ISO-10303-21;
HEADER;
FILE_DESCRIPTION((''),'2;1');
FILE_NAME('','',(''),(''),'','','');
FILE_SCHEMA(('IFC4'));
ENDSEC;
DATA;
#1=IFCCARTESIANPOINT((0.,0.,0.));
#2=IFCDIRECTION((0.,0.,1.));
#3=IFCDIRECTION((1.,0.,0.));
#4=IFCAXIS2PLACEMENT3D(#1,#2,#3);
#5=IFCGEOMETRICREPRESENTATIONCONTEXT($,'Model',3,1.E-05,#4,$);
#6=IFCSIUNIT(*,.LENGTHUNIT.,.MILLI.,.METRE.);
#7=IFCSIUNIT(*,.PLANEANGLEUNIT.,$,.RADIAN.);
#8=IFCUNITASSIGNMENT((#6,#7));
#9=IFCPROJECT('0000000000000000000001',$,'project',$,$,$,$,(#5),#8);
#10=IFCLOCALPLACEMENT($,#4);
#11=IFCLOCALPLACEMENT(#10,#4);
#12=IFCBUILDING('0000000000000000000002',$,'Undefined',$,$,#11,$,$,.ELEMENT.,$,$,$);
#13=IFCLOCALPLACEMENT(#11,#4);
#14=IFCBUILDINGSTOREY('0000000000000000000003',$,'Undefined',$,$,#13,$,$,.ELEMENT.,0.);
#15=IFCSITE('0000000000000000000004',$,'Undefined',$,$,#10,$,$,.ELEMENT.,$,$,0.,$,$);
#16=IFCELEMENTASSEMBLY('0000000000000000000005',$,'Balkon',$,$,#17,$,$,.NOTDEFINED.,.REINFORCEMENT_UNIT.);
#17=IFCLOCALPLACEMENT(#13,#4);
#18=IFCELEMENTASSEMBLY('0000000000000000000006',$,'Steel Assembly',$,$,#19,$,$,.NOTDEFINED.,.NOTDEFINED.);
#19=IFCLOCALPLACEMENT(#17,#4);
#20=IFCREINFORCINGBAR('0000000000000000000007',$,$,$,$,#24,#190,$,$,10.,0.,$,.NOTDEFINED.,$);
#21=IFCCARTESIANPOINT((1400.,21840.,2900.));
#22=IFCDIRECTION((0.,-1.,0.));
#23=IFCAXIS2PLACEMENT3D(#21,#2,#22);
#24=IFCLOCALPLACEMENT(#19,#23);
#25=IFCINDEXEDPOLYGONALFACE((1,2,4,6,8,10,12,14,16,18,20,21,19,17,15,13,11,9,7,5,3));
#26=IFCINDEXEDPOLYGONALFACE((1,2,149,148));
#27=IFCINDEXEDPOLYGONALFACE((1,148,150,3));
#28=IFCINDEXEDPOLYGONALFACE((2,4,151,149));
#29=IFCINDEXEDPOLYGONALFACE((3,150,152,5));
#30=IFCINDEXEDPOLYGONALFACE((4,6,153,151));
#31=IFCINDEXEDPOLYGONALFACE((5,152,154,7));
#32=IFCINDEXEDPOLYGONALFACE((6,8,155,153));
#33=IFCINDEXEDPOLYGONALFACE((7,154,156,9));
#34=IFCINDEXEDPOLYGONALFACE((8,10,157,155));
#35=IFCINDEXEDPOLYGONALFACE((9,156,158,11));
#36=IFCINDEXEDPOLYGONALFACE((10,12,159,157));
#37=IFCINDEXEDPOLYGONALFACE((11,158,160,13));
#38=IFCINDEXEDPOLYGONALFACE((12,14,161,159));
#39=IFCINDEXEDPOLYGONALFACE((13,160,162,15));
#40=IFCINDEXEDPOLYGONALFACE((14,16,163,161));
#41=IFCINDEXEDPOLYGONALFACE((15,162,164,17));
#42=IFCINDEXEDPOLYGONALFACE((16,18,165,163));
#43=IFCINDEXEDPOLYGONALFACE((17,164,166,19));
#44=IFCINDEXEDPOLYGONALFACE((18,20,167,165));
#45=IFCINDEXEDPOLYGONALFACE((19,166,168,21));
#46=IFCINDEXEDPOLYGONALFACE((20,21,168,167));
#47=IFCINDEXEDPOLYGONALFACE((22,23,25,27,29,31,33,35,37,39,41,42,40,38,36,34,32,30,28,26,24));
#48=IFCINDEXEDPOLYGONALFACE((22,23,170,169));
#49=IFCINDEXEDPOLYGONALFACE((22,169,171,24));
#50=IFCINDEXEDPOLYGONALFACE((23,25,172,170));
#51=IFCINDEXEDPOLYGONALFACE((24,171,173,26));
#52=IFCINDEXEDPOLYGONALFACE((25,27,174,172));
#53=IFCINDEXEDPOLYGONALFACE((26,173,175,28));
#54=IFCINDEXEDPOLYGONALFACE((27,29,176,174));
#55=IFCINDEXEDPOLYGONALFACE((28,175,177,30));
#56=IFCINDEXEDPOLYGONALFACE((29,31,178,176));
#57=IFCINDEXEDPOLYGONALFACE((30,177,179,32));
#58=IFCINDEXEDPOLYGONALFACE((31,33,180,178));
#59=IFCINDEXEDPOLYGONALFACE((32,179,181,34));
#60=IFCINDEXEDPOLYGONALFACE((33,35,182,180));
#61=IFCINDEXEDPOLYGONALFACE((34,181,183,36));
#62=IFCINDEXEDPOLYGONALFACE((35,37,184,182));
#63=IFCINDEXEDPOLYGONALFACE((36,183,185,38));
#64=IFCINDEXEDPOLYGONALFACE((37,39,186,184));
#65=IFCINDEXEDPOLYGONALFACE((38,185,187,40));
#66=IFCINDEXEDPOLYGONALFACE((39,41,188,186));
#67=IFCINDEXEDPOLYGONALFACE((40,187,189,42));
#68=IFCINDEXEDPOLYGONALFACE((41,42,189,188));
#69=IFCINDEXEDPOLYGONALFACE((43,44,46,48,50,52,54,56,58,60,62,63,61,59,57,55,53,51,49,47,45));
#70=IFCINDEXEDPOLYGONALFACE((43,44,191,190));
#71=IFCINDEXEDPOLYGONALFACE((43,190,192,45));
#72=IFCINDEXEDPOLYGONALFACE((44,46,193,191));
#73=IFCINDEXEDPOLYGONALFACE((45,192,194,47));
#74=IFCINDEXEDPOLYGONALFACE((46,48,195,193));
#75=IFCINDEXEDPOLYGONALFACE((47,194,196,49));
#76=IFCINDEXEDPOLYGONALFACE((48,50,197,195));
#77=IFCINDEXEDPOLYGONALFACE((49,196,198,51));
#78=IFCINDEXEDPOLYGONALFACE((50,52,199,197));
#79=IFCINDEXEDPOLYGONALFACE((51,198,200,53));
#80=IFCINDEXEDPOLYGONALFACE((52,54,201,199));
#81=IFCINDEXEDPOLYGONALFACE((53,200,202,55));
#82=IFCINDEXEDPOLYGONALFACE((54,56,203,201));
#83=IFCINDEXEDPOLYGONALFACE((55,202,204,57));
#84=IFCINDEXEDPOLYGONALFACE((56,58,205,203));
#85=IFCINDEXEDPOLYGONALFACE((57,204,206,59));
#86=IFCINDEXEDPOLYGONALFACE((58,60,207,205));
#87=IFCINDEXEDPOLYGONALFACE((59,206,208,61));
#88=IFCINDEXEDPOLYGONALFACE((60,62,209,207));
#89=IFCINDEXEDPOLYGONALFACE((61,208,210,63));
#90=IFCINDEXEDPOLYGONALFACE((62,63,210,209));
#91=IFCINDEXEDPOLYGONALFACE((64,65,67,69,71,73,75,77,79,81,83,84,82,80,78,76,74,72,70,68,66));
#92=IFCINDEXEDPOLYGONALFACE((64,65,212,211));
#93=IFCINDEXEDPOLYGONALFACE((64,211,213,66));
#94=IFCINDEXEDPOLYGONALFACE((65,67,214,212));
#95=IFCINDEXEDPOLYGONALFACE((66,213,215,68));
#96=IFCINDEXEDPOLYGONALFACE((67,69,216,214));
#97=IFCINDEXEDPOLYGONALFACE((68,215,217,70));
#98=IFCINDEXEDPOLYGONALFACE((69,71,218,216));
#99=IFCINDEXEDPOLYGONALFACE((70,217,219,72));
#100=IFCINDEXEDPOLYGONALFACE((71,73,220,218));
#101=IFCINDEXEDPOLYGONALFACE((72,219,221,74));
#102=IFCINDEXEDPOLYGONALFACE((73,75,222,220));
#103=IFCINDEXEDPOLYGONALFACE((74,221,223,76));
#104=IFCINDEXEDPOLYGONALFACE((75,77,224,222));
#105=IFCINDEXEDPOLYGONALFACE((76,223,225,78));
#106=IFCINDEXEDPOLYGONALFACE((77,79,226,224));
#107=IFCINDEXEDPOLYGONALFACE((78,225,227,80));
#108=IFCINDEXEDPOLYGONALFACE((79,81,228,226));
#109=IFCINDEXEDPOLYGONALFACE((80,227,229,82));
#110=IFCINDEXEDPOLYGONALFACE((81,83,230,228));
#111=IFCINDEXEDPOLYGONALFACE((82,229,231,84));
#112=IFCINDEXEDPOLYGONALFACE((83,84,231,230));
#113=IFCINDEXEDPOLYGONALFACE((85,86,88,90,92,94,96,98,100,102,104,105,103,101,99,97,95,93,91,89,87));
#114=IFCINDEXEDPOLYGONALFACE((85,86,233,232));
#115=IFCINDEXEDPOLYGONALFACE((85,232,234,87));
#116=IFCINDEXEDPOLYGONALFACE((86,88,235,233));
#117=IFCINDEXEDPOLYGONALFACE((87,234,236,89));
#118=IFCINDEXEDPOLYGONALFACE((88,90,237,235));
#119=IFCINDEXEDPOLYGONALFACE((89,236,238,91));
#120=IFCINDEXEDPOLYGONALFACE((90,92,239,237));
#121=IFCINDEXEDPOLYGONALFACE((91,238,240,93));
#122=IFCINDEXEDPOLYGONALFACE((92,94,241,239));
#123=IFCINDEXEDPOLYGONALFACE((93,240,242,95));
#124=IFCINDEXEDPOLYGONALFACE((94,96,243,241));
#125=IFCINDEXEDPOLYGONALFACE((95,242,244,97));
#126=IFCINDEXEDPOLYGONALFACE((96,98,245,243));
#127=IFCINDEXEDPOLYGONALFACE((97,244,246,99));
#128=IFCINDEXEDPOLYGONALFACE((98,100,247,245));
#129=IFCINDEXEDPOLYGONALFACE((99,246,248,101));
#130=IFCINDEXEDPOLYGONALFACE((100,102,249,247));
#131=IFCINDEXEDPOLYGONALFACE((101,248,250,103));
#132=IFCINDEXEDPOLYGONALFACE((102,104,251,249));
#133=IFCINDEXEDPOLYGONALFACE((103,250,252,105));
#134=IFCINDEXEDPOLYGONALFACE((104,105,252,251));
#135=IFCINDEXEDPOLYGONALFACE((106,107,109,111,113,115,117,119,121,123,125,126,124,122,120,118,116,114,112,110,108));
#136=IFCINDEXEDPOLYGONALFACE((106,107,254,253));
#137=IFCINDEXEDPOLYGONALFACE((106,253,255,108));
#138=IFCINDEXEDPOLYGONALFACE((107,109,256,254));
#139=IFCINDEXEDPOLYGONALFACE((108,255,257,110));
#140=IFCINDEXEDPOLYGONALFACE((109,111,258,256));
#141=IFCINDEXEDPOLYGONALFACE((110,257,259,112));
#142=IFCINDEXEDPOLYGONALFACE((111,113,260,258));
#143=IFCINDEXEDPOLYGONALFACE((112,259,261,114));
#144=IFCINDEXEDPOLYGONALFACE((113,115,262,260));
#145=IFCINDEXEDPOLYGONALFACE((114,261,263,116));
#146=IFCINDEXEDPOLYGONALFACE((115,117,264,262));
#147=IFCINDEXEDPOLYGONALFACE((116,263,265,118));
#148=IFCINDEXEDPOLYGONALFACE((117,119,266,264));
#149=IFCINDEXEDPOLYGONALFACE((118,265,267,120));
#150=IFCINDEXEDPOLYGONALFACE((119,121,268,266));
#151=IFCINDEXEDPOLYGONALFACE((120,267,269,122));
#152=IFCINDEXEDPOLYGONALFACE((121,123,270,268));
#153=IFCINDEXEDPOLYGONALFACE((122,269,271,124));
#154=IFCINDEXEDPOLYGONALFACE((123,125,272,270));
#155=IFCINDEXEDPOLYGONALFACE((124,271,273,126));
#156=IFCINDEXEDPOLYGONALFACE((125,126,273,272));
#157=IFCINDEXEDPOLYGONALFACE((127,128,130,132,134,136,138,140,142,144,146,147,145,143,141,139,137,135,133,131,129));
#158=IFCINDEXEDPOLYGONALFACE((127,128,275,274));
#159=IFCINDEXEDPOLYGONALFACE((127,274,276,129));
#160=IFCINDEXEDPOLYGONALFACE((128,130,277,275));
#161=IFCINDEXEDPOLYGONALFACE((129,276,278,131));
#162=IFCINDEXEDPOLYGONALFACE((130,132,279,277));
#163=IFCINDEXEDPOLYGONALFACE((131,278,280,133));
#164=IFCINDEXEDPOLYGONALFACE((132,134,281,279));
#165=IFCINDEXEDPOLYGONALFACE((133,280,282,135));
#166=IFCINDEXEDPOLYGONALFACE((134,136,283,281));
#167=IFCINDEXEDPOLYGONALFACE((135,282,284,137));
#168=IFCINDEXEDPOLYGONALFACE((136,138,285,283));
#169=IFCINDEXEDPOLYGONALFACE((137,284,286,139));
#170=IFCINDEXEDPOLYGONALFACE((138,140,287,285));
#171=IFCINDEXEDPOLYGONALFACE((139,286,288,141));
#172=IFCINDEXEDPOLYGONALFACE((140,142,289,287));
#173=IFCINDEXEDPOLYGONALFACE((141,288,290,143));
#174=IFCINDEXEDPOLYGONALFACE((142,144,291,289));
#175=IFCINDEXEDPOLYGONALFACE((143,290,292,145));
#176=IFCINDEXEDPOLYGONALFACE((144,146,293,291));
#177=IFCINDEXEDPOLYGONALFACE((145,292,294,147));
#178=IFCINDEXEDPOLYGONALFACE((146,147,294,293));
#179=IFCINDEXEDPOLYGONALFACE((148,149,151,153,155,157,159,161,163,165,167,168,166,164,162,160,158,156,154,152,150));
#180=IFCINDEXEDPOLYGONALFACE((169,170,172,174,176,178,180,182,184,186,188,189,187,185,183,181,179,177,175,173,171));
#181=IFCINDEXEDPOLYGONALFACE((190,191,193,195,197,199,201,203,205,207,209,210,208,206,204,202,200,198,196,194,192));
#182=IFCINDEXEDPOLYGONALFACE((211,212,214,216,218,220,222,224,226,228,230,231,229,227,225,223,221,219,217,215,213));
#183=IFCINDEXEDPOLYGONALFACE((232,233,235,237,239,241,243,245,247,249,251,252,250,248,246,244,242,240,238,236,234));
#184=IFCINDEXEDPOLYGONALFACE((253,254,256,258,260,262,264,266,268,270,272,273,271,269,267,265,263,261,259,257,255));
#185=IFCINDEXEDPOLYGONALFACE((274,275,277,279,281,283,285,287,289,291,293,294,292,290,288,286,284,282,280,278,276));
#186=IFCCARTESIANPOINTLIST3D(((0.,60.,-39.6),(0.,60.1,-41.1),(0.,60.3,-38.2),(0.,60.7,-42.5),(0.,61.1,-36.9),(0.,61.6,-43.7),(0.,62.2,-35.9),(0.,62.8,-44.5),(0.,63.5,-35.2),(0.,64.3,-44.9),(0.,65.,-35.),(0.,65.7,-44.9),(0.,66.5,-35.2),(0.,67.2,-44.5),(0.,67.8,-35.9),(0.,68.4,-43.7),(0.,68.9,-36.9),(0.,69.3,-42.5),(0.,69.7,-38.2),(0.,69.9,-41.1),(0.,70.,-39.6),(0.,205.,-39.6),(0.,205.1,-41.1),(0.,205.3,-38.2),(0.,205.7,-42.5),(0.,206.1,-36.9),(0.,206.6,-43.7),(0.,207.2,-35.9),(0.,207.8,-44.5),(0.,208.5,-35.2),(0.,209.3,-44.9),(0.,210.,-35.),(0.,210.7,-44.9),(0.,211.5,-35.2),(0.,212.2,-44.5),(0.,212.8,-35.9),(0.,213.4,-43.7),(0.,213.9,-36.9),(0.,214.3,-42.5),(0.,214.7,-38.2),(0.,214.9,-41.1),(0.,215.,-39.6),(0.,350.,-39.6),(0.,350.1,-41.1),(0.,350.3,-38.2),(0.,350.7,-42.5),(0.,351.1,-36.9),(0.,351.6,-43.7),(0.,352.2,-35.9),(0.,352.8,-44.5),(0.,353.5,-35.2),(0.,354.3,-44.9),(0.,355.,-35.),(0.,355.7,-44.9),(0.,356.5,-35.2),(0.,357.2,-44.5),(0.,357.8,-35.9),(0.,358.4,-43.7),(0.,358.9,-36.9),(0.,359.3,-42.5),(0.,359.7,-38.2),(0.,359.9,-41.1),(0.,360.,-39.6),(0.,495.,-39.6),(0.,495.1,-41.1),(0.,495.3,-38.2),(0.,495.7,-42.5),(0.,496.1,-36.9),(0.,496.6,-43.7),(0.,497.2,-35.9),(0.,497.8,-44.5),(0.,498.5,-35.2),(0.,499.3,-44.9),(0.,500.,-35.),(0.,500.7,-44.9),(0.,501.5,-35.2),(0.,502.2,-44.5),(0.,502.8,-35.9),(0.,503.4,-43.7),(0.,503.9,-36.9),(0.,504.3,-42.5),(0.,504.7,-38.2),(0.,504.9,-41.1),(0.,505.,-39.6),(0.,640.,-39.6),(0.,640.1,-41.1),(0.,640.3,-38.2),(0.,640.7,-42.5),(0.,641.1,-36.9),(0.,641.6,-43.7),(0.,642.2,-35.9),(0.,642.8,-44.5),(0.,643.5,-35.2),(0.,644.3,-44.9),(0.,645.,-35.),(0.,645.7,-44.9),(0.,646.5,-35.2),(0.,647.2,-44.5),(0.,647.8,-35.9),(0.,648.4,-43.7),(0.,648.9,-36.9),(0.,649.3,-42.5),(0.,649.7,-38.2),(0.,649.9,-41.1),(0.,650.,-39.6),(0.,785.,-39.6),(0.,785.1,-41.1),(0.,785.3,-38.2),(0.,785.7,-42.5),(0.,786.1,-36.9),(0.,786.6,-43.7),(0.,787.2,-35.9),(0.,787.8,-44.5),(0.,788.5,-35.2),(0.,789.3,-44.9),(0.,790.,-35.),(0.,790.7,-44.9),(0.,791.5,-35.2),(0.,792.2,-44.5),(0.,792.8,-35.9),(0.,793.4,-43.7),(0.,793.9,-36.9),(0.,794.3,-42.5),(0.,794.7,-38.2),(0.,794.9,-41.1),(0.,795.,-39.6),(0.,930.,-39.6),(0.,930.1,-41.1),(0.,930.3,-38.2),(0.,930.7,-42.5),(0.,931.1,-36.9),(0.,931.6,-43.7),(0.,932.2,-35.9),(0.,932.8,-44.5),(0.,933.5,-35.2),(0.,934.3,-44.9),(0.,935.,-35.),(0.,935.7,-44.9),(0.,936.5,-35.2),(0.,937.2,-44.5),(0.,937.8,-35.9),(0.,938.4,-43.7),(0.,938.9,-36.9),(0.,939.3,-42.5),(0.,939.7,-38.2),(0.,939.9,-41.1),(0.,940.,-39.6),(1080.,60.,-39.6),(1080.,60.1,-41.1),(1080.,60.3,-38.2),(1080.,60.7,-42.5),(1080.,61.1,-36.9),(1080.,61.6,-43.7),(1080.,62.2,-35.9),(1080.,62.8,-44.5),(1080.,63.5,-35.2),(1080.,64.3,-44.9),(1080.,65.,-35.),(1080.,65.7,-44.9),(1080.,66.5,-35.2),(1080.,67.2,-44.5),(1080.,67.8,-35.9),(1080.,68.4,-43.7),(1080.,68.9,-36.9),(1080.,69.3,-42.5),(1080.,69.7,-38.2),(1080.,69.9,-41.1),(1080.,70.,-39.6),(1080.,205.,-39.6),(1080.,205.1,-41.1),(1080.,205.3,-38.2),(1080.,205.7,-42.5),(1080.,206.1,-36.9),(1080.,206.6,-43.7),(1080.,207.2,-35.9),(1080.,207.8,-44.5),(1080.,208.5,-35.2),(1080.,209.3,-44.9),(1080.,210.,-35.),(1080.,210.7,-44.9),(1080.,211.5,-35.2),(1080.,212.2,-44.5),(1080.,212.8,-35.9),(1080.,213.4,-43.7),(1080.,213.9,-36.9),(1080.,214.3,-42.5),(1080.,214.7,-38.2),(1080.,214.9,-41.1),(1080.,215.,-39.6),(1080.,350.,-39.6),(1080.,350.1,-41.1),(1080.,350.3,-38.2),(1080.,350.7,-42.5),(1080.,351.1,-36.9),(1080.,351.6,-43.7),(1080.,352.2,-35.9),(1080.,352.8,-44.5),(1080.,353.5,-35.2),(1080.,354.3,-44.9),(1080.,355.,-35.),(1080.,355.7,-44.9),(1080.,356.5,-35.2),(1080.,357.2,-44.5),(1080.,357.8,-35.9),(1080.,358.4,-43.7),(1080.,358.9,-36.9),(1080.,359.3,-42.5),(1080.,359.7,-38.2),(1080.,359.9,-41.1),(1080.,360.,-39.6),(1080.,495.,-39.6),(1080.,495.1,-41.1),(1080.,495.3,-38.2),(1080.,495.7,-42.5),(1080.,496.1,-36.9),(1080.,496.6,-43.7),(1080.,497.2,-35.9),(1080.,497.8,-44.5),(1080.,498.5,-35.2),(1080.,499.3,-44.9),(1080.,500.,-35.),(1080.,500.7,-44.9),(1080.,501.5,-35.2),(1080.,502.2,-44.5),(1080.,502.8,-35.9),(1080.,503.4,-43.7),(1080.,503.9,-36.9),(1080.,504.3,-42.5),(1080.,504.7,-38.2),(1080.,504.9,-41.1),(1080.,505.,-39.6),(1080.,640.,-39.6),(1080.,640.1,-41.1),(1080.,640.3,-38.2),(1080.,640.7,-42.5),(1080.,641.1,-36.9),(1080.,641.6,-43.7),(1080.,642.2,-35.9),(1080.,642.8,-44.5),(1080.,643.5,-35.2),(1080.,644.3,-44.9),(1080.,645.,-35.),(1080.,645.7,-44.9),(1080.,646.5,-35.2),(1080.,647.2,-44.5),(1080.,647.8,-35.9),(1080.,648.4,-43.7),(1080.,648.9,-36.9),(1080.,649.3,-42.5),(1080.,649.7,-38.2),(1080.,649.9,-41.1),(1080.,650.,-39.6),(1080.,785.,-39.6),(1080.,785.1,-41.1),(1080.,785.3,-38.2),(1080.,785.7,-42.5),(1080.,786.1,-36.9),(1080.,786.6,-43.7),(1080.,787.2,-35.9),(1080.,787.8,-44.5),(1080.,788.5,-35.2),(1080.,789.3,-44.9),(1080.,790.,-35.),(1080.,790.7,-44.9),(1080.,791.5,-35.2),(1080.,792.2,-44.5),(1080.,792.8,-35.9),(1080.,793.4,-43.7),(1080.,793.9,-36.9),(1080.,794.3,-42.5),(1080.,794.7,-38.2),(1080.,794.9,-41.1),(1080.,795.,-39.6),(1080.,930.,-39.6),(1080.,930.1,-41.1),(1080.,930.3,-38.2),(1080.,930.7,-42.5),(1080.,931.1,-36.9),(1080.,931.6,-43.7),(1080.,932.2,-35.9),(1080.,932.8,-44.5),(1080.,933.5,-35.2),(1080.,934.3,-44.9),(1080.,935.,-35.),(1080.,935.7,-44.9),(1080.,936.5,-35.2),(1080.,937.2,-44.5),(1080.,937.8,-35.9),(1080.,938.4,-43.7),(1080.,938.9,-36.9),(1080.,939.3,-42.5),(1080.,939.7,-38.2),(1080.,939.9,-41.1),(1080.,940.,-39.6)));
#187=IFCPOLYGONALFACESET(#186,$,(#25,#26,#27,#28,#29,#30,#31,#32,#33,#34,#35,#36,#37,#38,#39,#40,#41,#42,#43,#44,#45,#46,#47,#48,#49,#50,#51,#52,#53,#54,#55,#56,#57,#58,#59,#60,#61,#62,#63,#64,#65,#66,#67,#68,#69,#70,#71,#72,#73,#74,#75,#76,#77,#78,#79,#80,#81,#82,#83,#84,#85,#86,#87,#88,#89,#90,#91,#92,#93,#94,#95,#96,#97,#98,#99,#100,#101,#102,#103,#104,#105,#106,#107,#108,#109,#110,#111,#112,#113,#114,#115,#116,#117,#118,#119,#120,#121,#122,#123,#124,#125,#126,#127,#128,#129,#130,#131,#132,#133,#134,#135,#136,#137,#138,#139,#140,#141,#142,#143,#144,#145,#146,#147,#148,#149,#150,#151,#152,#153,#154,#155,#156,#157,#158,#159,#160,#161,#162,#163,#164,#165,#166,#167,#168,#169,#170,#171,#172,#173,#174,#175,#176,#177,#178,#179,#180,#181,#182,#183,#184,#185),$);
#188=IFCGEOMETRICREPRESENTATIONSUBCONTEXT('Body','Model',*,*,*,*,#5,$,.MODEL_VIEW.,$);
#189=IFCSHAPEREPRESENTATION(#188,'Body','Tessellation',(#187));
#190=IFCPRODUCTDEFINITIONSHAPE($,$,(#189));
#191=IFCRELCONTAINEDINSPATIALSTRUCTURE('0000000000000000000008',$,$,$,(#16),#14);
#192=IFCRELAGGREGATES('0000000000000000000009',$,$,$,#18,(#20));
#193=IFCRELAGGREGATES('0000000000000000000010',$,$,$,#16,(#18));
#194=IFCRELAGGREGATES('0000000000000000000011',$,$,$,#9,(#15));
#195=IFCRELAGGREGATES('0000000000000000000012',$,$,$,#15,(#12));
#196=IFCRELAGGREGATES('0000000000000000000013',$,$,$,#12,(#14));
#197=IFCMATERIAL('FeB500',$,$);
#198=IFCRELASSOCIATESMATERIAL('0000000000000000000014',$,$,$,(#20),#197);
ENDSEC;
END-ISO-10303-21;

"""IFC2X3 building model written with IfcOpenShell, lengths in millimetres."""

from ifc_helpers import new_model, entity, si_unit, frame, origin_with_axes, place, context, subcontext, project, spatial, source, transform, mapped, material, element, aggregate, save


model = new_model("IFC2X3")

# Units and contexts
model_context = context("Model", 3, precision=1e-05, world=origin_with_axes())
body_context = subcontext(model_context, "Body", "Model", "MODEL_VIEW")
ifc_project = project(units=[si_unit("LENGTHUNIT", "METRE", prefix="MILLI"), si_unit("PLANEANGLEUNIT", "RADIAN")], contexts=[model_context])

# Site, building, storey
site_placement = place(None, origin_with_axes())
site = spatial("IfcSite", under=ifc_project, at=site_placement, Name="Undefined", CompositionType="ELEMENT", RefElevation=0.0)
building_placement = place(site_placement, origin_with_axes())
building = spatial("IfcBuilding", under=site, at=building_placement, Name="Undefined", CompositionType="ELEMENT")
storey_placement = place(building_placement, origin_with_axes())
storey = spatial("IfcBuildingStorey", under=building, at=storey_placement, Name="Undefined", CompositionType="ELEMENT", Elevation=0.0)

# Element assemblies, reinforcing bar
assembly_1_placement = place(storey_placement, origin_with_axes())
assembly_1 = element("IfcElementAssembly", 1, at=assembly_1_placement, inside=storey, Name="Balkon", AssemblyPlace="NOTDEFINED", PredefinedType="REINFORCEMENT_UNIT")
assembly_2_placement = place(assembly_1_placement, origin_with_axes())
assembly_2 = element("IfcElementAssembly", 2, at=assembly_2_placement, Name="Steel Assembly", AssemblyPlace="NOTDEFINED", PredefinedType="NOTDEFINED")
ifc_material_1 = material(Name="FeB500")
shared_shape_1 = source(origin_with_axes(), body_context, "Body", "AdvancedSweptSolid", [
    entity("IfcSweptDiskSolid", entity("IfcTrimmedCurve", entity("IfcLine", entity("IfcCartesianPoint", [0.0, 0.0, 0.0]), entity("IfcVector", entity("IfcDirection", [1.0, 0.0, 0.0]), 1.0)), [entity("IfcParameterValue", 0.0)], [entity("IfcParameterValue", 1080.0)], True, "PARAMETER"), 5.0, None, 0.0, 1080.0),
])
shared_shape_2 = source(origin_with_axes(), body_context, "Body", "AdvancedSweptSolid", [
    entity("IfcSweptDiskSolid", entity("IfcTrimmedCurve", entity("IfcLine", entity("IfcCartesianPoint", [0.0, 0.0, 0.0]), entity("IfcVector", entity("IfcDirection", [1.0, 0.0, 0.0]), 1.0)), [entity("IfcParameterValue", 0.0)], [entity("IfcParameterValue", 1080.0)], True, "PARAMETER"), 5.0, None, 0.0, 1080.0),
])
shared_shape_3 = source(origin_with_axes(), body_context, "Body", "AdvancedSweptSolid", [
    entity("IfcSweptDiskSolid", entity("IfcTrimmedCurve", entity("IfcLine", entity("IfcCartesianPoint", [0.0, 0.0, 0.0]), entity("IfcVector", entity("IfcDirection", [1.0, 0.0, 0.0]), 1.0)), [entity("IfcParameterValue", 0.0)], [entity("IfcParameterValue", 1080.0)], True, "PARAMETER"), 5.0, None, 0.0, 1080.0),
])
shared_shape_4 = source(origin_with_axes(), body_context, "Body", "AdvancedSweptSolid", [
    entity("IfcSweptDiskSolid", entity("IfcTrimmedCurve", entity("IfcLine", entity("IfcCartesianPoint", [0.0, 0.0, 0.0]), entity("IfcVector", entity("IfcDirection", [1.0, 0.0, 0.0]), 1.0)), [entity("IfcParameterValue", 0.0)], [entity("IfcParameterValue", 1080.0)], True, "PARAMETER"), 5.0, None, 0.0, 1080.0),
])
shared_shape_5 = source(origin_with_axes(), body_context, "Body", "AdvancedSweptSolid", [
    entity("IfcSweptDiskSolid", entity("IfcTrimmedCurve", entity("IfcLine", entity("IfcCartesianPoint", [0.0, 0.0, 0.0]), entity("IfcVector", entity("IfcDirection", [1.0, 0.0, 0.0]), 1.0)), [entity("IfcParameterValue", 0.0)], [entity("IfcParameterValue", 1080.0)], True, "PARAMETER"), 5.0, None, 0.0, 1080.0),
])
shared_shape_6 = source(origin_with_axes(), body_context, "Body", "AdvancedSweptSolid", [
    entity("IfcSweptDiskSolid", entity("IfcTrimmedCurve", entity("IfcLine", entity("IfcCartesianPoint", [0.0, 0.0, 0.0]), entity("IfcVector", entity("IfcDirection", [1.0, 0.0, 0.0]), 1.0)), [entity("IfcParameterValue", 0.0)], [entity("IfcParameterValue", 1080.0)], True, "PARAMETER"), 5.0, None, 0.0, 1080.0),
])
shared_shape_7 = source(origin_with_axes(), body_context, "Body", "AdvancedSweptSolid", [
    entity("IfcSweptDiskSolid", entity("IfcTrimmedCurve", entity("IfcLine", entity("IfcCartesianPoint", [0.0, 0.0, 0.0]), entity("IfcVector", entity("IfcDirection", [1.0, 0.0, 0.0]), 1.0)), [entity("IfcParameterValue", 0.0)], [entity("IfcParameterValue", 1080.0)], True, "PARAMETER"), 5.0, None, 0.0, 1080.0),
])
reinforcing_bar_1_placement = place(assembly_2_placement, frame((1400.0, 21840.0, 2900.0), z_axis=(0.0, 0.0, 1.0), x_axis=(0.0, -1.0, 0.0)))
reinforcing_bar_1 = element("IfcReinforcingBar", 3, at=reinforcing_bar_1_placement, material=ifc_material_1, BarRole="NOTDEFINED", CrossSectionArea=0.0, NominalDiameter=10.0, context=body_context, shape_type="MappedRepresentation", body=[
    mapped(shared_shape_1, transform((0.0, 65.0, -40.0))),
    mapped(shared_shape_2, transform((0.0, 210.0, -40.0))),
    mapped(shared_shape_3, transform((0.0, 355.0, -40.0))),
    mapped(shared_shape_4, transform((0.0, 500.0, -40.0))),
    mapped(shared_shape_5, transform((0.0, 645.0, -40.0))),
    mapped(shared_shape_6, transform((0.0, 790.0, -40.0))),
    mapped(shared_shape_7, transform((0.0, 935.0, -40.0))),
])
aggregate(assembly_2, [reinforcing_bar_1])
aggregate(assembly_1, [assembly_2])

save(model, "model.ifc")
